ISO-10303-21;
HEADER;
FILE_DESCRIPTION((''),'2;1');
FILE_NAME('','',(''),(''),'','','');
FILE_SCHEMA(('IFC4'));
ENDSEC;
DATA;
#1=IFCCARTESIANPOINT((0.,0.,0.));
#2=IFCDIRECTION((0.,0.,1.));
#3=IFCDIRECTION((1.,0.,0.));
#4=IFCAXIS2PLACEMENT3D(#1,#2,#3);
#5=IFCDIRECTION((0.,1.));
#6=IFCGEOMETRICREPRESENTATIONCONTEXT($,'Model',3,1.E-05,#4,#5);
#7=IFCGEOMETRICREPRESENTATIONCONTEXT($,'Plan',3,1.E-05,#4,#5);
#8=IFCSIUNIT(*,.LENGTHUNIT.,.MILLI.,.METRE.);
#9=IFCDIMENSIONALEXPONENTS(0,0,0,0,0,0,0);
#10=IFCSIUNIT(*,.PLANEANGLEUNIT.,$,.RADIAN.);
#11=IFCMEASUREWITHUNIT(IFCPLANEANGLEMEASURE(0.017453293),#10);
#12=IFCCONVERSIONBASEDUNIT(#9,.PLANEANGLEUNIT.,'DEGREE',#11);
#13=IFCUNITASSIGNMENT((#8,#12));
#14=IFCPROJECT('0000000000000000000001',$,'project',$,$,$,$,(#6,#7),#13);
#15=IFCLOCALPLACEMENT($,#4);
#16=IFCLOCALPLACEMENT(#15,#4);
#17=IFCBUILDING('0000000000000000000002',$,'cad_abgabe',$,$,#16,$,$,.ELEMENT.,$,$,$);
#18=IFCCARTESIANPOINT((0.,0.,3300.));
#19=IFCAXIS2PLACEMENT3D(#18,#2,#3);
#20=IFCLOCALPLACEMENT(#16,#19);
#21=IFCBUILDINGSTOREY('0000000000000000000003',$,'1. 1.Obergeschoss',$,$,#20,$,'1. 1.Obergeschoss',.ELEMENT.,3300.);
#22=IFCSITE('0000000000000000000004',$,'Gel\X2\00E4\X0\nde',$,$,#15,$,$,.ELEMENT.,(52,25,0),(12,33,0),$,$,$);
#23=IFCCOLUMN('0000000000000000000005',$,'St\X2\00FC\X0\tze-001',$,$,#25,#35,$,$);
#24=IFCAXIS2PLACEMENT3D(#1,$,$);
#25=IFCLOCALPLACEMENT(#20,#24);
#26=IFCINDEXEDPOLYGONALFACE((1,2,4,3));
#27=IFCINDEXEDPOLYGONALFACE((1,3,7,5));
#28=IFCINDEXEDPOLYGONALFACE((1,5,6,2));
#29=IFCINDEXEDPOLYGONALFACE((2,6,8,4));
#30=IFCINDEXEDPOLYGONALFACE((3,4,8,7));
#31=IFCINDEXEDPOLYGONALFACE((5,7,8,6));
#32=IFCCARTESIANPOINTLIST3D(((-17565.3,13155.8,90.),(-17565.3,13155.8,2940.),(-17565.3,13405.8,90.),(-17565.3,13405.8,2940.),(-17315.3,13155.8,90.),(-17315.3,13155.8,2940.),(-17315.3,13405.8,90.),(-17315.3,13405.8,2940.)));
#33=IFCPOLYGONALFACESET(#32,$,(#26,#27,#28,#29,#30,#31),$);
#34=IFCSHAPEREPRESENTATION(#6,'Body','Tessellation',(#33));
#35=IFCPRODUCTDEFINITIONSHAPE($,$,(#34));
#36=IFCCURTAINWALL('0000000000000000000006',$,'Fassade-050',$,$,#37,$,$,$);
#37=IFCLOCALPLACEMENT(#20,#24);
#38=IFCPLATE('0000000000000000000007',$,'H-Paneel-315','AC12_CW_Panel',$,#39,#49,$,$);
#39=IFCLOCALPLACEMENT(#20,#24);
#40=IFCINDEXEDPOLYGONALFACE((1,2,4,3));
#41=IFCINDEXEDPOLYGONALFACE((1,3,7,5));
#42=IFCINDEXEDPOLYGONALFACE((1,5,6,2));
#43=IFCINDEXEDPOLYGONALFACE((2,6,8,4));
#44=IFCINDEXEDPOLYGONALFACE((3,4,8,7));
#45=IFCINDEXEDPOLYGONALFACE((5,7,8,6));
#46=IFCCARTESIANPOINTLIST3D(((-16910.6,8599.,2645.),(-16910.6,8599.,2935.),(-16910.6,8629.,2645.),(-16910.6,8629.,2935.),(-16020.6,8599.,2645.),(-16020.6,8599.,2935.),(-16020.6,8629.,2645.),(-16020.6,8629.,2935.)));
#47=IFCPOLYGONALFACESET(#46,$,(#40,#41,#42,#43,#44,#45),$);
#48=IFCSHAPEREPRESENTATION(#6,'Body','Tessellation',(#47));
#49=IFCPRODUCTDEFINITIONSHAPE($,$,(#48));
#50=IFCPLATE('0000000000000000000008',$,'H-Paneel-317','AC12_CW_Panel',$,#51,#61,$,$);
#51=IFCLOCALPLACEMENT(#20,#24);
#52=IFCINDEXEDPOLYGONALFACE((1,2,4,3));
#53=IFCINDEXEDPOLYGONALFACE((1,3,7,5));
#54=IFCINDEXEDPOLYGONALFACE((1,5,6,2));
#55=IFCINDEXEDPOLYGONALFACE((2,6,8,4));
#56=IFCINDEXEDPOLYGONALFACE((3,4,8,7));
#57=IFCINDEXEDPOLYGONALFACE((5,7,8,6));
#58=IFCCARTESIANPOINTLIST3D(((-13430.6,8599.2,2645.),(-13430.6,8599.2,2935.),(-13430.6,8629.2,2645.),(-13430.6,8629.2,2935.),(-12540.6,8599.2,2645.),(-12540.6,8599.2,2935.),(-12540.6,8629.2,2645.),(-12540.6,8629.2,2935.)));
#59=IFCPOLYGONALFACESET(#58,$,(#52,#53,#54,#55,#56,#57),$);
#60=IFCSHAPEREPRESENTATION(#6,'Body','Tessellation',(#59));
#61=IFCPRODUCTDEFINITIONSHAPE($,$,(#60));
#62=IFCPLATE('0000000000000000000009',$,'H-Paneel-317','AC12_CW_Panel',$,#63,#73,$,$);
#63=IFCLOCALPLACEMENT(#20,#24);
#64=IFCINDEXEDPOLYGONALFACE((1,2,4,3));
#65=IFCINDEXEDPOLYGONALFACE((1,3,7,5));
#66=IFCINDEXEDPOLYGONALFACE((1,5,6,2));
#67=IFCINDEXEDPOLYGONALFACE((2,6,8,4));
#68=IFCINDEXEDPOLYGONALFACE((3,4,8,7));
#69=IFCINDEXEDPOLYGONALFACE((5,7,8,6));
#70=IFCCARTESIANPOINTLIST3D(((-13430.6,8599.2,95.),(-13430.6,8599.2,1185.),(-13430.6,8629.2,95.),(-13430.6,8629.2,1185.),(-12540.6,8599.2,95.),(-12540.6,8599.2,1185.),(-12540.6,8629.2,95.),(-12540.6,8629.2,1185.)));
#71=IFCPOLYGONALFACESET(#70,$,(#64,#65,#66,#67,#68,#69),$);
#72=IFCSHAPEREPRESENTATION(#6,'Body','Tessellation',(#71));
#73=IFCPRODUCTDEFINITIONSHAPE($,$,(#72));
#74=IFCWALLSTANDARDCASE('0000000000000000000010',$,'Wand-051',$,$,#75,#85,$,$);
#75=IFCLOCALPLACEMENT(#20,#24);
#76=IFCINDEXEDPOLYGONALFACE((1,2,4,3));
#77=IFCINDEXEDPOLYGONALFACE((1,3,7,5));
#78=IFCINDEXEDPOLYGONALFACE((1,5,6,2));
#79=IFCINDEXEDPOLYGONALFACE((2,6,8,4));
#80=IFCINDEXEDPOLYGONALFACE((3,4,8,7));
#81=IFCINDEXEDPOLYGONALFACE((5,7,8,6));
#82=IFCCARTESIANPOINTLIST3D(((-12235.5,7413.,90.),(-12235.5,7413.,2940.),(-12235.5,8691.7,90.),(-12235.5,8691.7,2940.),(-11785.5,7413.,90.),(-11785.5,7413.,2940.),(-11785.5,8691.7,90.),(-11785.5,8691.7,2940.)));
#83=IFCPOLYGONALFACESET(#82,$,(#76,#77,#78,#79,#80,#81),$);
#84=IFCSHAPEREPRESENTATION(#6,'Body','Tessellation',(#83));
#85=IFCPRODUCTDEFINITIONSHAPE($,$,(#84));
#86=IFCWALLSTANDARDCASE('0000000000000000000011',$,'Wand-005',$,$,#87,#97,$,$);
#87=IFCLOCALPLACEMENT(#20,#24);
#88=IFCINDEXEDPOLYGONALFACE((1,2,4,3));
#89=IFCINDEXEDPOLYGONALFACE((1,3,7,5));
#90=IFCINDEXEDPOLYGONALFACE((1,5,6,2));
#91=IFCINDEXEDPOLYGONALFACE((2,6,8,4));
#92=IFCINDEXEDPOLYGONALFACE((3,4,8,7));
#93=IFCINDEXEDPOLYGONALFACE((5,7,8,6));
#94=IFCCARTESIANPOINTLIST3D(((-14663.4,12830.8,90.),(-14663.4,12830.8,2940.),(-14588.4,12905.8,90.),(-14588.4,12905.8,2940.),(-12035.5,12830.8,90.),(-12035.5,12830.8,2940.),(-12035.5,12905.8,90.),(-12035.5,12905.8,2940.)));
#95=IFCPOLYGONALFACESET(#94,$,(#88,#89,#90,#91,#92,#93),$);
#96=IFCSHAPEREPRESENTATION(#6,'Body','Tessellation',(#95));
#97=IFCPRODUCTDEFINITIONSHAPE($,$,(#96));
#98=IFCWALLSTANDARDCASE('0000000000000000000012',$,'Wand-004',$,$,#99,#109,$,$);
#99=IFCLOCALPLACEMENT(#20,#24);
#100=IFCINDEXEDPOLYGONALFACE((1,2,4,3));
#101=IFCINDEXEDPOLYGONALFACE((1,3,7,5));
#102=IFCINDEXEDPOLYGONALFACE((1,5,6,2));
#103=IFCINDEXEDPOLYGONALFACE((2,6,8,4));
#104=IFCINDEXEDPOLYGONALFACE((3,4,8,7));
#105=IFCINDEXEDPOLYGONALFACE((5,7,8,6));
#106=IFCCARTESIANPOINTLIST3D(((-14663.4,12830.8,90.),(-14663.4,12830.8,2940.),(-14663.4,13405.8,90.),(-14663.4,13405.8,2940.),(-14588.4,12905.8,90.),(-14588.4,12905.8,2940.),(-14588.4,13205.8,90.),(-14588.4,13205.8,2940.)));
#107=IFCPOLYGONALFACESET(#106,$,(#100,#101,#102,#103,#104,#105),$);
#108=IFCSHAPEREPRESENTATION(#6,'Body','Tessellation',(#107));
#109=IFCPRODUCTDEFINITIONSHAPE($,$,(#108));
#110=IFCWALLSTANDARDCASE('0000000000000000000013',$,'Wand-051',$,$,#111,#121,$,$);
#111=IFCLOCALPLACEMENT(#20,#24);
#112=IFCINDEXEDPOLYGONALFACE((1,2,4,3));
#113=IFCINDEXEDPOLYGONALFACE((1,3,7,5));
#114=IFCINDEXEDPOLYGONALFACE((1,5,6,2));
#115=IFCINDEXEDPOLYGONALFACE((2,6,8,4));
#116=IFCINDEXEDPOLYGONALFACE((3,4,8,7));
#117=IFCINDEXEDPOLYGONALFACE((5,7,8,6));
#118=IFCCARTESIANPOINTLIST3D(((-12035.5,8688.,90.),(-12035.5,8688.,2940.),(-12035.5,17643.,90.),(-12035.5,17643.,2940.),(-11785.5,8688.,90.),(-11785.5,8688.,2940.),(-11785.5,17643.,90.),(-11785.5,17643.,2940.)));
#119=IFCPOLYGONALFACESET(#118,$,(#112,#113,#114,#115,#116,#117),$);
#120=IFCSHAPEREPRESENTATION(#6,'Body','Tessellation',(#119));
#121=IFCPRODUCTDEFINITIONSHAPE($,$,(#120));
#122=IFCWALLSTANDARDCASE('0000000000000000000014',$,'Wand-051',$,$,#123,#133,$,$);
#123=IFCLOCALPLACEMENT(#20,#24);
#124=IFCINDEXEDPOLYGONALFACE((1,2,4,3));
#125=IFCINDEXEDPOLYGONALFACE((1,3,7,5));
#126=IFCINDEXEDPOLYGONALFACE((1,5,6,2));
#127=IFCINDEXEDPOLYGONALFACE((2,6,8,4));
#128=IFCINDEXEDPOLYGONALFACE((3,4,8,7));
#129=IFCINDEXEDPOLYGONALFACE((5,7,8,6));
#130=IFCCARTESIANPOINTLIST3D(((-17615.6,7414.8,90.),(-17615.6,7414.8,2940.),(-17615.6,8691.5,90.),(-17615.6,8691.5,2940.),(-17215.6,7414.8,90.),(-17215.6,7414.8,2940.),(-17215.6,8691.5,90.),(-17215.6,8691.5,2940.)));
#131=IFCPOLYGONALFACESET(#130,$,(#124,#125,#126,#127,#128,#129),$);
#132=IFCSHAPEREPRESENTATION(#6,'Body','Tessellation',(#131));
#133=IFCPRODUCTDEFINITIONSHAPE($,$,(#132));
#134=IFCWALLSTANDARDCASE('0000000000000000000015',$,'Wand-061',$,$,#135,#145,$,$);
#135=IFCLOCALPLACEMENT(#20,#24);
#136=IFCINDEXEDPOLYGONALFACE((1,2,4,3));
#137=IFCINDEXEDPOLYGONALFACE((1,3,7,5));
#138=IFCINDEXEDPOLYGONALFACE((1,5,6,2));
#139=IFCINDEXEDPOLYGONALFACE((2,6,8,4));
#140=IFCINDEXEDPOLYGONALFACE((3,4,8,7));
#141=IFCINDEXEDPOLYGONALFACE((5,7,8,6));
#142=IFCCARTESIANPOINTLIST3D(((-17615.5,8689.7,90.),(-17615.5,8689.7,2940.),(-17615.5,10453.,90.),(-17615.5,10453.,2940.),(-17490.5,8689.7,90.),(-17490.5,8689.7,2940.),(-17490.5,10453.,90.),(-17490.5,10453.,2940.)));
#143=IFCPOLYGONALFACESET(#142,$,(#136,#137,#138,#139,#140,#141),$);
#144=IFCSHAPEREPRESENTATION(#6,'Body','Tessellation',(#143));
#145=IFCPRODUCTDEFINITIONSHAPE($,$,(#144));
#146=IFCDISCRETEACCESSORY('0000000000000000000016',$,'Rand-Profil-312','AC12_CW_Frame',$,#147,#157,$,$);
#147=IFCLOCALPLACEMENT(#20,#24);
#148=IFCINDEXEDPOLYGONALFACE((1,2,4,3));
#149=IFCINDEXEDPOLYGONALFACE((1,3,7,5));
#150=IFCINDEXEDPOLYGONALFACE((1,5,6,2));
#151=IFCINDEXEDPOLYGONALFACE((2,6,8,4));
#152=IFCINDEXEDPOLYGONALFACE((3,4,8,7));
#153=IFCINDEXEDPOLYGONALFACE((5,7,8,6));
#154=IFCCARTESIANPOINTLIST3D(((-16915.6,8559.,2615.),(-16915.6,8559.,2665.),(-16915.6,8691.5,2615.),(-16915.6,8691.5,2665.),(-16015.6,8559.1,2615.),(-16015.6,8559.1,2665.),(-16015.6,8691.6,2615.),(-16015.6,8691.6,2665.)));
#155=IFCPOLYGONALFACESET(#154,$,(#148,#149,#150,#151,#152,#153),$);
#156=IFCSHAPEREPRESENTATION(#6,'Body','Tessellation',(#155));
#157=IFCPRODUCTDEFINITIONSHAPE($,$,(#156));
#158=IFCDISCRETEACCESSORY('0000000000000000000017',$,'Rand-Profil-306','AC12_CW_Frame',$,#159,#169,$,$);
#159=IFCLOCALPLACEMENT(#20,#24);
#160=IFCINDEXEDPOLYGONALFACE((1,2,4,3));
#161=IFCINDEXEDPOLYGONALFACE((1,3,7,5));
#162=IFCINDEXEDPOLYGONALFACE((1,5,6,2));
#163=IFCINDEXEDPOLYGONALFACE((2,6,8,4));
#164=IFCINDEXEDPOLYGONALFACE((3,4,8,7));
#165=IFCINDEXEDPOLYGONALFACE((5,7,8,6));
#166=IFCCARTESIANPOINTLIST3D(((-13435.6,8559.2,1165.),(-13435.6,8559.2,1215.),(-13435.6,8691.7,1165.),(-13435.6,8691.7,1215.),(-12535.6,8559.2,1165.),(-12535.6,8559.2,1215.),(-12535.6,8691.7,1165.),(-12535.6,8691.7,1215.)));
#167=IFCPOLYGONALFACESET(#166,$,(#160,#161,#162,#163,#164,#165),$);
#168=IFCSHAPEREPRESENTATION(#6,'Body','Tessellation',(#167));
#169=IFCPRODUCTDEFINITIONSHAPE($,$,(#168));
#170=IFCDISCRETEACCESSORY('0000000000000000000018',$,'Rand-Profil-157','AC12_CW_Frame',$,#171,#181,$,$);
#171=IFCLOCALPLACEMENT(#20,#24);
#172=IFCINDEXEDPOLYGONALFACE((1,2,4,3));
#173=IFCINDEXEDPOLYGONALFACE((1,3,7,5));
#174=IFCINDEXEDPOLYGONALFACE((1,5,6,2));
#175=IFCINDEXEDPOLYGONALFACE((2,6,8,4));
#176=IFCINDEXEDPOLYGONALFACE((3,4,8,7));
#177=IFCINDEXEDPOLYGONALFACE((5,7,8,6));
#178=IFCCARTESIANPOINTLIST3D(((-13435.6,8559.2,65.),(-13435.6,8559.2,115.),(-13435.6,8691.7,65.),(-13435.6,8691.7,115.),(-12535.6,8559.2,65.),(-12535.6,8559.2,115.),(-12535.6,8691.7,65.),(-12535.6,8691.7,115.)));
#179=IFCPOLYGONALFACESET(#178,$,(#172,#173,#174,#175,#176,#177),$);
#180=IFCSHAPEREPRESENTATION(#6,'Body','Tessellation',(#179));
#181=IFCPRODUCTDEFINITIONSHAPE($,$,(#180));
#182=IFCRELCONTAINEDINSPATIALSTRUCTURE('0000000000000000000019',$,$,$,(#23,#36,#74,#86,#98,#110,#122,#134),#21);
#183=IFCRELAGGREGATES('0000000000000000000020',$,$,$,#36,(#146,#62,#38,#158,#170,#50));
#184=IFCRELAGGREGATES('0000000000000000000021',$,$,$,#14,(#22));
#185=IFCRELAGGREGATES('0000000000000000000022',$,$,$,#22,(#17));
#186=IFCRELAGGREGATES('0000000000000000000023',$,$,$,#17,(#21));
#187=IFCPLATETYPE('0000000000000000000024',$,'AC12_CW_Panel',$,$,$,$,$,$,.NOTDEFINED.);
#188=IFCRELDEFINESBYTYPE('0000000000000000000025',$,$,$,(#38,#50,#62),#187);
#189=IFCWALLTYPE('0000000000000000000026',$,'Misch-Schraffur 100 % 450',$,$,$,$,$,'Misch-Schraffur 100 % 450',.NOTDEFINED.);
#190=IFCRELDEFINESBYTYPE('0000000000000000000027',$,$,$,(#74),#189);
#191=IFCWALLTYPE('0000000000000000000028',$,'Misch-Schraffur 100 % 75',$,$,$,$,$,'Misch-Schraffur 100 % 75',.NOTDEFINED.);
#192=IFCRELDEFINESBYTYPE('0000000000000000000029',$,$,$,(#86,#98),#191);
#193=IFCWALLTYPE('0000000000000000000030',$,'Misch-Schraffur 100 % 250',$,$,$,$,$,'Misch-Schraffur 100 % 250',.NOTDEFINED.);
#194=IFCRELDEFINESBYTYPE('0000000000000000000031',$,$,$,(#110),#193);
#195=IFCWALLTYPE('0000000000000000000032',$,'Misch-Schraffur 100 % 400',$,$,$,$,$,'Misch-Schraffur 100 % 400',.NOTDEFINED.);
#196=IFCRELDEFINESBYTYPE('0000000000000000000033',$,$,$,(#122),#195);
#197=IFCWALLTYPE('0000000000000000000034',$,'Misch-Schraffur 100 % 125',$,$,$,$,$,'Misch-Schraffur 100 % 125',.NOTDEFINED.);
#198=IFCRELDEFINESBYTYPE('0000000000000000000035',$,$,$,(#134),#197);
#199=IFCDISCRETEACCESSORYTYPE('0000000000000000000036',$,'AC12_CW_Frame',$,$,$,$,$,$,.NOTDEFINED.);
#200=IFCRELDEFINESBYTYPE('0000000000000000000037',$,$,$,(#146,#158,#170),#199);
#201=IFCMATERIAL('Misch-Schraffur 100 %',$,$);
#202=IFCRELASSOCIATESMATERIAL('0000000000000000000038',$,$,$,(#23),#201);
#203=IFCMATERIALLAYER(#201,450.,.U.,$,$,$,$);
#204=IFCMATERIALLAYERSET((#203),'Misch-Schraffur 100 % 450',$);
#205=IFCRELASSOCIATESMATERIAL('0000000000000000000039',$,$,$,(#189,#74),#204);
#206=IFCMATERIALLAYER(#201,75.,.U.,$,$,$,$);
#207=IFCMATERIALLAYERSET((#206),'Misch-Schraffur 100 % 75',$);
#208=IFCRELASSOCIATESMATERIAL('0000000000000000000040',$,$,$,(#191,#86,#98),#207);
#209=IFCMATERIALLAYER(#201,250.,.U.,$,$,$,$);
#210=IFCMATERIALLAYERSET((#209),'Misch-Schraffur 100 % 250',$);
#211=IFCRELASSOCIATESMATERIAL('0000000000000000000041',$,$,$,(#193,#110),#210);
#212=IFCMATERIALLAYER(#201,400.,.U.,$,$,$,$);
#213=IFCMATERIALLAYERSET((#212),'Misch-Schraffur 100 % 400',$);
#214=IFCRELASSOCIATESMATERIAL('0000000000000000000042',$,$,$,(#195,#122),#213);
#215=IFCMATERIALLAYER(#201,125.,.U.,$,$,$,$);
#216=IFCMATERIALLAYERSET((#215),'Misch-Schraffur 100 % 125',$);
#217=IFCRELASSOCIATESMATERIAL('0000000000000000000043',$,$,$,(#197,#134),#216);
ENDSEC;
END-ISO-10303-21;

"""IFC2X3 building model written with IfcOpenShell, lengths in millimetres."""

from ifc_helpers import new_model, entity, si_unit, converted_unit, direction, frame, origin_with_axes, origin_2d_with_axis, place, context, project, spatial, polyline, rectangle, outline, extrude, source, transform, mapped, material, layer, layer_set, layer_usage, type_object, element, aggregate, save


model = new_model("IFC2X3")

# Units and contexts
model_context = context("Model", 3, precision=1e-05, world=origin_with_axes(), true_north=direction((0.0, 1.0)))
plan_context = context("Plan", 3, precision=1e-05, world=origin_with_axes(), true_north=direction((0.0, 1.0)))
ifc_project = project(units=[si_unit("LENGTHUNIT", "METRE", prefix="MILLI"), converted_unit("PLANEANGLEUNIT", "DEGREE", entity("IfcPlaneAngleMeasure", 0.017453293), si_unit("PLANEANGLEUNIT", "RADIAN"), dimensions=[0, 0, 0, 0, 0, 0, 0])], contexts=[model_context, plan_context])

# Site, building, storey
site_placement = place(None, origin_with_axes())
site = spatial("IfcSite", under=ifc_project, at=site_placement, Name="Gelände", CompositionType="ELEMENT", RefLatitude=(52, 25, 0), RefLongitude=(12, 33, 0))
building_placement = place(site_placement, origin_with_axes())
building = spatial("IfcBuilding", under=site, at=building_placement, Name="cad_abgabe", CompositionType="ELEMENT")
storey_placement = place(building_placement, frame((0.0, 0.0, 3300.0), z_axis=(0.0, 0.0, 1.0), x_axis=(1.0, 0.0, 0.0)))
storey = spatial("IfcBuildingStorey", under=building, at=storey_placement, Name="1. 1.Obergeschoss", LongName="1. 1.Obergeschoss", CompositionType="ELEMENT", Elevation=3300.0)

# Column
ifc_material = material(Name="Misch-Schraffur 100 %")
column_placement = place(storey_placement, frame((-17440.3, 13280.8, 90.0), z_axis=(0.0, 0.0, 1.0), x_axis=(1.0, 0.0, 0.0)))
element("IfcColumn", 1, at=column_placement, inside=storey, material=ifc_material, Name="Stütze-001", context=model_context, shape_type="SweptSolid", body=[
    extrude(rectangle(XDim=250.0, YDim=250.0, at=origin_2d_with_axis()), origin_with_axes(), (0.0, 0.0, 1.0), 2850.0),
])

# Curtain wall, plates
curtain_wall_placement = place(storey_placement, frame((-17190.6, 8614.0, 90.0), z_axis=(0.0, 0.0, 1.0), x_axis=(1.0, 0.000045, 0.0)))
curtain_wall = element("IfcCurtainWall", 2, at=curtain_wall_placement, inside=storey, Name="Fassade-050")
plate_type = type_object("IfcPlateType", Name="AC12_CW_Panel", PredefinedType="NOTDEFINED")
shared_shape_1 = source(origin_with_axes(), model_context, "Body", "SweptSolid", [
    extrude(outline(polyline([(0.0, 0.0), (890.0, 0.0), (890.0, -30.0), (0.0, -30.0), (0.0, 0.0)])), origin_with_axes(), (0.0, 0.0, 1.0), 290.0),
])
plate_1_placement = place(storey_placement, frame((-16910.6, 8629.0, 2645.0), z_axis=(0.0, 0.0, 1.0), x_axis=(1.0, 0.000045, 0.0)))
plate_1 = element("IfcPlate", 3, at=plate_1_placement, type_object=plate_type, Name="H-Paneel-315", Description="AC12_CW_Panel", context=model_context, shape_type="MappedRepresentation", body=[
    mapped(shared_shape_1, transform((0.0, 0.0, 0.0), scale=1.0)),
])
plate_2_placement = place(storey_placement, frame((-13430.6, 8629.2, 2645.0), z_axis=(0.0, 0.0, 1.0), x_axis=(1.0, 0.000045, 0.0)))
plate_2 = element("IfcPlate", 4, at=plate_2_placement, type_object=plate_type, Name="H-Paneel-317", Description="AC12_CW_Panel", context=model_context, shape_type="MappedRepresentation", body=[
    mapped(shared_shape_1, transform((0.0, 0.0, 0.0), scale=1.0)),
])
shared_shape_2 = source(origin_with_axes(), model_context, "Body", "SweptSolid", [
    extrude(outline(polyline([(0.0, 0.0), (890.0, 0.0), (890.0, -30.0), (0.0, -30.0), (0.0, 0.0)])), origin_with_axes(), (0.0, 0.0, 1.0), 1090.0),
])
plate_3_placement = place(storey_placement, frame((-13430.6, 8629.2, 95.0), z_axis=(0.0, 0.0, 1.0), x_axis=(1.0, 0.000045, 0.0)))
plate_3 = element("IfcPlate", 5, at=plate_3_placement, type_object=plate_type, Name="H-Paneel-317", Description="AC12_CW_Panel", context=model_context, shape_type="MappedRepresentation", body=[
    mapped(shared_shape_2, transform((0.0, 0.0, 0.0), scale=1.0)),
])

# Walls
ifc_layer_1 = layer(ifc_material, 450.0, ventilated="UNKNOWN")
ifc_layer_set_1 = layer_set([ifc_layer_1], Name="Misch-Schraffur 100 % 450")
ifc_layer_usage_1 = layer_usage(ifc_layer_set_1, "AXIS2", "POSITIVE", 0.0)
wall_type_1 = type_object("IfcWallType", Name="Misch-Schraffur 100 % 450", ElementType="Misch-Schraffur 100 % 450", PredefinedType="NOTDEFINED", material=ifc_layer_set_1)
wall_1_placement = place(storey_placement, frame((-11785.5, 7413.0, 90.0), z_axis=(0.0, 0.0, 1.0), x_axis=(0.0, 1.0, 0.0)))
element("IfcWallStandardCase", 6, at=wall_1_placement, inside=storey, type_object=wall_type_1, material=ifc_layer_usage_1, Name="Wand-051", context=model_context, shape_type="SweptSolid", body=[
    extrude(outline(polyline([(0.0, 0.0), (1278.7, 0.0), (1278.7, 450.0), (0.0, 450.0), (0.0, 0.0)])), origin_with_axes(), (0.0, 0.0, 1.0), 2850.0),
])
ifc_layer_2 = layer(ifc_material, 75.0, ventilated="UNKNOWN")
ifc_layer_set_2 = layer_set([ifc_layer_2], Name="Misch-Schraffur 100 % 75")
ifc_layer_usage_2 = layer_usage(ifc_layer_set_2, "AXIS2", "POSITIVE", 0.0)
wall_type_2 = type_object("IfcWallType", Name="Misch-Schraffur 100 % 75", ElementType="Misch-Schraffur 100 % 75", PredefinedType="NOTDEFINED", material=ifc_layer_set_2)
wall_2_placement = place(storey_placement, frame((-14663.4, 12830.8, 90.0), z_axis=(0.0, 0.0, 1.0), x_axis=(1.0, 0.0, 0.0)))
element("IfcWallStandardCase", 7, at=wall_2_placement, inside=storey, type_object=wall_type_2, material=ifc_layer_usage_2, Name="Wand-005", context=model_context, shape_type="SweptSolid", body=[
    extrude(outline(polyline([(0.0, 0.0), (2627.9, 0.0), (2627.9, 75.0), (75.0, 75.0), (0.0, 0.0)])), origin_with_axes(), (0.0, 0.0, 1.0), 2850.0),
])
ifc_layer_usage_3 = layer_usage(ifc_layer_set_2, "AXIS2", "POSITIVE", 0.0)
wall_3_placement = place(storey_placement, frame((-14663.4, 13205.8, 90.0), z_axis=(0.0, 0.0, 1.0), x_axis=(-0.000001, -1.0, 0.0)))
element("IfcWallStandardCase", 8, at=wall_3_placement, inside=storey, type_object=wall_type_2, material=ifc_layer_usage_3, Name="Wand-004", context=model_context, shape_type="SweptSolid", body=[
    extrude(outline(polyline([(-200.0, 0.0), (375.0, 0.0), (300.0, 75.0), (0.0, 75.0), (-200.0, 0.0)])), origin_with_axes(), (0.0, 0.0, 1.0), 2850.0),
])
ifc_layer_3 = layer(ifc_material, 250.0, ventilated="UNKNOWN")
ifc_layer_set_3 = layer_set([ifc_layer_3], Name="Misch-Schraffur 100 % 250")
ifc_layer_usage_4 = layer_usage(ifc_layer_set_3, "AXIS2", "POSITIVE", 0.0)
wall_type_3 = type_object("IfcWallType", Name="Misch-Schraffur 100 % 250", ElementType="Misch-Schraffur 100 % 250", PredefinedType="NOTDEFINED", material=ifc_layer_set_3)
wall_4_placement = place(storey_placement, frame((-11785.5, 8688.0, 90.0), z_axis=(0.0, 0.0, 1.0), x_axis=(0.0, 1.0, 0.0)))
element("IfcWallStandardCase", 9, at=wall_4_placement, inside=storey, type_object=wall_type_3, material=ifc_layer_usage_4, Name="Wand-051", context=model_context, shape_type="SweptSolid", body=[
    extrude(outline(polyline([(0.0, 0.0), (8955.0, 0.0), (8955.0, 250.0), (0.0, 250.0), (0.0, 0.0)])), origin_with_axes(), (0.0, 0.0, 1.0), 2850.0),
])
ifc_layer_4 = layer(ifc_material, 400.0, ventilated="UNKNOWN")
ifc_layer_set_4 = layer_set([ifc_layer_4], Name="Misch-Schraffur 100 % 400")
ifc_layer_usage_5 = layer_usage(ifc_layer_set_4, "AXIS2", "POSITIVE", 0.0)
wall_type_4 = type_object("IfcWallType", Name="Misch-Schraffur 100 % 400", ElementType="Misch-Schraffur 100 % 400", PredefinedType="NOTDEFINED", material=ifc_layer_set_4)
wall_5_placement = place(storey_placement, frame((-17215.6, 7414.8, 90.0), z_axis=(0.0, 0.0, 1.0), x_axis=(0.0, 1.0, 0.0)))
element("IfcWallStandardCase", 10, at=wall_5_placement, inside=storey, type_object=wall_type_4, material=ifc_layer_usage_5, Name="Wand-051", context=model_context, shape_type="SweptSolid", body=[
    extrude(outline(polyline([(0.0, 0.0), (1276.7, 0.0), (1276.7, 400.0), (0.0, 400.0), (0.0, 0.0)])), origin_with_axes(), (0.0, 0.0, 1.0), 2850.0),
])
ifc_layer_5 = layer(ifc_material, 125.0, ventilated="UNKNOWN")
ifc_layer_set_5 = layer_set([ifc_layer_5], Name="Misch-Schraffur 100 % 125")
ifc_layer_usage_6 = layer_usage(ifc_layer_set_5, "AXIS2", "NEGATIVE", 0.0)
wall_type_5 = type_object("IfcWallType", Name="Misch-Schraffur 100 % 125", ElementType="Misch-Schraffur 100 % 125", PredefinedType="NOTDEFINED", material=ifc_layer_set_5)
wall_6_placement = place(storey_placement, frame((-17615.5, 8689.7, 90.0), z_axis=(0.0, 0.0, 1.0), x_axis=(0.000007, 1.0, 0.0)))
element("IfcWallStandardCase", 11, at=wall_6_placement, inside=storey, type_object=wall_type_5, material=ifc_layer_usage_6, Name="Wand-061", context=model_context, shape_type="SweptSolid", body=[
    extrude(outline(polyline([(0.0, -125.0), (1763.3, -125.0), (1763.3, 0.0), (0.0, 0.0), (0.0, -125.0)])), origin_with_axes(), (0.0, 0.0, 1.0), 2850.0),
])

# Discrete accessories
discrete_accessory_type = type_object("IfcDiscreteAccessoryType", Name="AC12_CW_Frame")
shared_shape_3 = source(origin_with_axes(), model_context, "Body", "SweptSolid", [
    extrude(outline(polyline([(0.0, 0.0), (132.5, 0.0), (132.5, -900.0), (0.0, -900.0), (0.0, 0.0)])), origin_with_axes(), (0.0, 0.0, 1.0), 50.0),
])
discrete_accessory_1_placement = place(storey_placement, frame((-16015.6, 8691.6, 2615.0), z_axis=(0.0, 0.0, 1.0), x_axis=(0.000045, -1.0, 0.0)))
discrete_accessory_1 = element("IfcDiscreteAccessory", 12, at=discrete_accessory_1_placement, type_object=discrete_accessory_type, Name="Rand-Profil-312", Description="AC12_CW_Frame", context=model_context, shape_type="MappedRepresentation", body=[
    mapped(shared_shape_3, transform((0.0, 0.0, 0.0), scale=1.0)),
])
discrete_accessory_2_placement = place(storey_placement, frame((-13435.6, 8691.7, 1215.0), z_axis=(0.0, 0.0, -1.0), x_axis=(0.000045, -1.0, 0.0)))
discrete_accessory_2 = element("IfcDiscreteAccessory", 13, at=discrete_accessory_2_placement, type_object=discrete_accessory_type, Name="Rand-Profil-306", Description="AC12_CW_Frame", context=model_context, shape_type="MappedRepresentation", body=[
    mapped(shared_shape_3, transform((0.0, 0.0, 0.0), scale=1.0)),
])
discrete_accessory_3_placement = place(storey_placement, frame((-13435.6, 8691.7, 115.0), z_axis=(0.0, 0.0, -1.0), x_axis=(0.000045, -1.0, 0.0)))
discrete_accessory_3 = element("IfcDiscreteAccessory", 14, at=discrete_accessory_3_placement, type_object=discrete_accessory_type, Name="Rand-Profil-157", Description="AC12_CW_Frame", context=model_context, shape_type="MappedRepresentation", body=[
    mapped(shared_shape_3, transform((0.0, 0.0, 0.0), scale=1.0)),
])
aggregate(curtain_wall, [discrete_accessory_1, plate_3, plate_1, discrete_accessory_2, discrete_accessory_3, plate_2])

save(model, "model.ifc")
